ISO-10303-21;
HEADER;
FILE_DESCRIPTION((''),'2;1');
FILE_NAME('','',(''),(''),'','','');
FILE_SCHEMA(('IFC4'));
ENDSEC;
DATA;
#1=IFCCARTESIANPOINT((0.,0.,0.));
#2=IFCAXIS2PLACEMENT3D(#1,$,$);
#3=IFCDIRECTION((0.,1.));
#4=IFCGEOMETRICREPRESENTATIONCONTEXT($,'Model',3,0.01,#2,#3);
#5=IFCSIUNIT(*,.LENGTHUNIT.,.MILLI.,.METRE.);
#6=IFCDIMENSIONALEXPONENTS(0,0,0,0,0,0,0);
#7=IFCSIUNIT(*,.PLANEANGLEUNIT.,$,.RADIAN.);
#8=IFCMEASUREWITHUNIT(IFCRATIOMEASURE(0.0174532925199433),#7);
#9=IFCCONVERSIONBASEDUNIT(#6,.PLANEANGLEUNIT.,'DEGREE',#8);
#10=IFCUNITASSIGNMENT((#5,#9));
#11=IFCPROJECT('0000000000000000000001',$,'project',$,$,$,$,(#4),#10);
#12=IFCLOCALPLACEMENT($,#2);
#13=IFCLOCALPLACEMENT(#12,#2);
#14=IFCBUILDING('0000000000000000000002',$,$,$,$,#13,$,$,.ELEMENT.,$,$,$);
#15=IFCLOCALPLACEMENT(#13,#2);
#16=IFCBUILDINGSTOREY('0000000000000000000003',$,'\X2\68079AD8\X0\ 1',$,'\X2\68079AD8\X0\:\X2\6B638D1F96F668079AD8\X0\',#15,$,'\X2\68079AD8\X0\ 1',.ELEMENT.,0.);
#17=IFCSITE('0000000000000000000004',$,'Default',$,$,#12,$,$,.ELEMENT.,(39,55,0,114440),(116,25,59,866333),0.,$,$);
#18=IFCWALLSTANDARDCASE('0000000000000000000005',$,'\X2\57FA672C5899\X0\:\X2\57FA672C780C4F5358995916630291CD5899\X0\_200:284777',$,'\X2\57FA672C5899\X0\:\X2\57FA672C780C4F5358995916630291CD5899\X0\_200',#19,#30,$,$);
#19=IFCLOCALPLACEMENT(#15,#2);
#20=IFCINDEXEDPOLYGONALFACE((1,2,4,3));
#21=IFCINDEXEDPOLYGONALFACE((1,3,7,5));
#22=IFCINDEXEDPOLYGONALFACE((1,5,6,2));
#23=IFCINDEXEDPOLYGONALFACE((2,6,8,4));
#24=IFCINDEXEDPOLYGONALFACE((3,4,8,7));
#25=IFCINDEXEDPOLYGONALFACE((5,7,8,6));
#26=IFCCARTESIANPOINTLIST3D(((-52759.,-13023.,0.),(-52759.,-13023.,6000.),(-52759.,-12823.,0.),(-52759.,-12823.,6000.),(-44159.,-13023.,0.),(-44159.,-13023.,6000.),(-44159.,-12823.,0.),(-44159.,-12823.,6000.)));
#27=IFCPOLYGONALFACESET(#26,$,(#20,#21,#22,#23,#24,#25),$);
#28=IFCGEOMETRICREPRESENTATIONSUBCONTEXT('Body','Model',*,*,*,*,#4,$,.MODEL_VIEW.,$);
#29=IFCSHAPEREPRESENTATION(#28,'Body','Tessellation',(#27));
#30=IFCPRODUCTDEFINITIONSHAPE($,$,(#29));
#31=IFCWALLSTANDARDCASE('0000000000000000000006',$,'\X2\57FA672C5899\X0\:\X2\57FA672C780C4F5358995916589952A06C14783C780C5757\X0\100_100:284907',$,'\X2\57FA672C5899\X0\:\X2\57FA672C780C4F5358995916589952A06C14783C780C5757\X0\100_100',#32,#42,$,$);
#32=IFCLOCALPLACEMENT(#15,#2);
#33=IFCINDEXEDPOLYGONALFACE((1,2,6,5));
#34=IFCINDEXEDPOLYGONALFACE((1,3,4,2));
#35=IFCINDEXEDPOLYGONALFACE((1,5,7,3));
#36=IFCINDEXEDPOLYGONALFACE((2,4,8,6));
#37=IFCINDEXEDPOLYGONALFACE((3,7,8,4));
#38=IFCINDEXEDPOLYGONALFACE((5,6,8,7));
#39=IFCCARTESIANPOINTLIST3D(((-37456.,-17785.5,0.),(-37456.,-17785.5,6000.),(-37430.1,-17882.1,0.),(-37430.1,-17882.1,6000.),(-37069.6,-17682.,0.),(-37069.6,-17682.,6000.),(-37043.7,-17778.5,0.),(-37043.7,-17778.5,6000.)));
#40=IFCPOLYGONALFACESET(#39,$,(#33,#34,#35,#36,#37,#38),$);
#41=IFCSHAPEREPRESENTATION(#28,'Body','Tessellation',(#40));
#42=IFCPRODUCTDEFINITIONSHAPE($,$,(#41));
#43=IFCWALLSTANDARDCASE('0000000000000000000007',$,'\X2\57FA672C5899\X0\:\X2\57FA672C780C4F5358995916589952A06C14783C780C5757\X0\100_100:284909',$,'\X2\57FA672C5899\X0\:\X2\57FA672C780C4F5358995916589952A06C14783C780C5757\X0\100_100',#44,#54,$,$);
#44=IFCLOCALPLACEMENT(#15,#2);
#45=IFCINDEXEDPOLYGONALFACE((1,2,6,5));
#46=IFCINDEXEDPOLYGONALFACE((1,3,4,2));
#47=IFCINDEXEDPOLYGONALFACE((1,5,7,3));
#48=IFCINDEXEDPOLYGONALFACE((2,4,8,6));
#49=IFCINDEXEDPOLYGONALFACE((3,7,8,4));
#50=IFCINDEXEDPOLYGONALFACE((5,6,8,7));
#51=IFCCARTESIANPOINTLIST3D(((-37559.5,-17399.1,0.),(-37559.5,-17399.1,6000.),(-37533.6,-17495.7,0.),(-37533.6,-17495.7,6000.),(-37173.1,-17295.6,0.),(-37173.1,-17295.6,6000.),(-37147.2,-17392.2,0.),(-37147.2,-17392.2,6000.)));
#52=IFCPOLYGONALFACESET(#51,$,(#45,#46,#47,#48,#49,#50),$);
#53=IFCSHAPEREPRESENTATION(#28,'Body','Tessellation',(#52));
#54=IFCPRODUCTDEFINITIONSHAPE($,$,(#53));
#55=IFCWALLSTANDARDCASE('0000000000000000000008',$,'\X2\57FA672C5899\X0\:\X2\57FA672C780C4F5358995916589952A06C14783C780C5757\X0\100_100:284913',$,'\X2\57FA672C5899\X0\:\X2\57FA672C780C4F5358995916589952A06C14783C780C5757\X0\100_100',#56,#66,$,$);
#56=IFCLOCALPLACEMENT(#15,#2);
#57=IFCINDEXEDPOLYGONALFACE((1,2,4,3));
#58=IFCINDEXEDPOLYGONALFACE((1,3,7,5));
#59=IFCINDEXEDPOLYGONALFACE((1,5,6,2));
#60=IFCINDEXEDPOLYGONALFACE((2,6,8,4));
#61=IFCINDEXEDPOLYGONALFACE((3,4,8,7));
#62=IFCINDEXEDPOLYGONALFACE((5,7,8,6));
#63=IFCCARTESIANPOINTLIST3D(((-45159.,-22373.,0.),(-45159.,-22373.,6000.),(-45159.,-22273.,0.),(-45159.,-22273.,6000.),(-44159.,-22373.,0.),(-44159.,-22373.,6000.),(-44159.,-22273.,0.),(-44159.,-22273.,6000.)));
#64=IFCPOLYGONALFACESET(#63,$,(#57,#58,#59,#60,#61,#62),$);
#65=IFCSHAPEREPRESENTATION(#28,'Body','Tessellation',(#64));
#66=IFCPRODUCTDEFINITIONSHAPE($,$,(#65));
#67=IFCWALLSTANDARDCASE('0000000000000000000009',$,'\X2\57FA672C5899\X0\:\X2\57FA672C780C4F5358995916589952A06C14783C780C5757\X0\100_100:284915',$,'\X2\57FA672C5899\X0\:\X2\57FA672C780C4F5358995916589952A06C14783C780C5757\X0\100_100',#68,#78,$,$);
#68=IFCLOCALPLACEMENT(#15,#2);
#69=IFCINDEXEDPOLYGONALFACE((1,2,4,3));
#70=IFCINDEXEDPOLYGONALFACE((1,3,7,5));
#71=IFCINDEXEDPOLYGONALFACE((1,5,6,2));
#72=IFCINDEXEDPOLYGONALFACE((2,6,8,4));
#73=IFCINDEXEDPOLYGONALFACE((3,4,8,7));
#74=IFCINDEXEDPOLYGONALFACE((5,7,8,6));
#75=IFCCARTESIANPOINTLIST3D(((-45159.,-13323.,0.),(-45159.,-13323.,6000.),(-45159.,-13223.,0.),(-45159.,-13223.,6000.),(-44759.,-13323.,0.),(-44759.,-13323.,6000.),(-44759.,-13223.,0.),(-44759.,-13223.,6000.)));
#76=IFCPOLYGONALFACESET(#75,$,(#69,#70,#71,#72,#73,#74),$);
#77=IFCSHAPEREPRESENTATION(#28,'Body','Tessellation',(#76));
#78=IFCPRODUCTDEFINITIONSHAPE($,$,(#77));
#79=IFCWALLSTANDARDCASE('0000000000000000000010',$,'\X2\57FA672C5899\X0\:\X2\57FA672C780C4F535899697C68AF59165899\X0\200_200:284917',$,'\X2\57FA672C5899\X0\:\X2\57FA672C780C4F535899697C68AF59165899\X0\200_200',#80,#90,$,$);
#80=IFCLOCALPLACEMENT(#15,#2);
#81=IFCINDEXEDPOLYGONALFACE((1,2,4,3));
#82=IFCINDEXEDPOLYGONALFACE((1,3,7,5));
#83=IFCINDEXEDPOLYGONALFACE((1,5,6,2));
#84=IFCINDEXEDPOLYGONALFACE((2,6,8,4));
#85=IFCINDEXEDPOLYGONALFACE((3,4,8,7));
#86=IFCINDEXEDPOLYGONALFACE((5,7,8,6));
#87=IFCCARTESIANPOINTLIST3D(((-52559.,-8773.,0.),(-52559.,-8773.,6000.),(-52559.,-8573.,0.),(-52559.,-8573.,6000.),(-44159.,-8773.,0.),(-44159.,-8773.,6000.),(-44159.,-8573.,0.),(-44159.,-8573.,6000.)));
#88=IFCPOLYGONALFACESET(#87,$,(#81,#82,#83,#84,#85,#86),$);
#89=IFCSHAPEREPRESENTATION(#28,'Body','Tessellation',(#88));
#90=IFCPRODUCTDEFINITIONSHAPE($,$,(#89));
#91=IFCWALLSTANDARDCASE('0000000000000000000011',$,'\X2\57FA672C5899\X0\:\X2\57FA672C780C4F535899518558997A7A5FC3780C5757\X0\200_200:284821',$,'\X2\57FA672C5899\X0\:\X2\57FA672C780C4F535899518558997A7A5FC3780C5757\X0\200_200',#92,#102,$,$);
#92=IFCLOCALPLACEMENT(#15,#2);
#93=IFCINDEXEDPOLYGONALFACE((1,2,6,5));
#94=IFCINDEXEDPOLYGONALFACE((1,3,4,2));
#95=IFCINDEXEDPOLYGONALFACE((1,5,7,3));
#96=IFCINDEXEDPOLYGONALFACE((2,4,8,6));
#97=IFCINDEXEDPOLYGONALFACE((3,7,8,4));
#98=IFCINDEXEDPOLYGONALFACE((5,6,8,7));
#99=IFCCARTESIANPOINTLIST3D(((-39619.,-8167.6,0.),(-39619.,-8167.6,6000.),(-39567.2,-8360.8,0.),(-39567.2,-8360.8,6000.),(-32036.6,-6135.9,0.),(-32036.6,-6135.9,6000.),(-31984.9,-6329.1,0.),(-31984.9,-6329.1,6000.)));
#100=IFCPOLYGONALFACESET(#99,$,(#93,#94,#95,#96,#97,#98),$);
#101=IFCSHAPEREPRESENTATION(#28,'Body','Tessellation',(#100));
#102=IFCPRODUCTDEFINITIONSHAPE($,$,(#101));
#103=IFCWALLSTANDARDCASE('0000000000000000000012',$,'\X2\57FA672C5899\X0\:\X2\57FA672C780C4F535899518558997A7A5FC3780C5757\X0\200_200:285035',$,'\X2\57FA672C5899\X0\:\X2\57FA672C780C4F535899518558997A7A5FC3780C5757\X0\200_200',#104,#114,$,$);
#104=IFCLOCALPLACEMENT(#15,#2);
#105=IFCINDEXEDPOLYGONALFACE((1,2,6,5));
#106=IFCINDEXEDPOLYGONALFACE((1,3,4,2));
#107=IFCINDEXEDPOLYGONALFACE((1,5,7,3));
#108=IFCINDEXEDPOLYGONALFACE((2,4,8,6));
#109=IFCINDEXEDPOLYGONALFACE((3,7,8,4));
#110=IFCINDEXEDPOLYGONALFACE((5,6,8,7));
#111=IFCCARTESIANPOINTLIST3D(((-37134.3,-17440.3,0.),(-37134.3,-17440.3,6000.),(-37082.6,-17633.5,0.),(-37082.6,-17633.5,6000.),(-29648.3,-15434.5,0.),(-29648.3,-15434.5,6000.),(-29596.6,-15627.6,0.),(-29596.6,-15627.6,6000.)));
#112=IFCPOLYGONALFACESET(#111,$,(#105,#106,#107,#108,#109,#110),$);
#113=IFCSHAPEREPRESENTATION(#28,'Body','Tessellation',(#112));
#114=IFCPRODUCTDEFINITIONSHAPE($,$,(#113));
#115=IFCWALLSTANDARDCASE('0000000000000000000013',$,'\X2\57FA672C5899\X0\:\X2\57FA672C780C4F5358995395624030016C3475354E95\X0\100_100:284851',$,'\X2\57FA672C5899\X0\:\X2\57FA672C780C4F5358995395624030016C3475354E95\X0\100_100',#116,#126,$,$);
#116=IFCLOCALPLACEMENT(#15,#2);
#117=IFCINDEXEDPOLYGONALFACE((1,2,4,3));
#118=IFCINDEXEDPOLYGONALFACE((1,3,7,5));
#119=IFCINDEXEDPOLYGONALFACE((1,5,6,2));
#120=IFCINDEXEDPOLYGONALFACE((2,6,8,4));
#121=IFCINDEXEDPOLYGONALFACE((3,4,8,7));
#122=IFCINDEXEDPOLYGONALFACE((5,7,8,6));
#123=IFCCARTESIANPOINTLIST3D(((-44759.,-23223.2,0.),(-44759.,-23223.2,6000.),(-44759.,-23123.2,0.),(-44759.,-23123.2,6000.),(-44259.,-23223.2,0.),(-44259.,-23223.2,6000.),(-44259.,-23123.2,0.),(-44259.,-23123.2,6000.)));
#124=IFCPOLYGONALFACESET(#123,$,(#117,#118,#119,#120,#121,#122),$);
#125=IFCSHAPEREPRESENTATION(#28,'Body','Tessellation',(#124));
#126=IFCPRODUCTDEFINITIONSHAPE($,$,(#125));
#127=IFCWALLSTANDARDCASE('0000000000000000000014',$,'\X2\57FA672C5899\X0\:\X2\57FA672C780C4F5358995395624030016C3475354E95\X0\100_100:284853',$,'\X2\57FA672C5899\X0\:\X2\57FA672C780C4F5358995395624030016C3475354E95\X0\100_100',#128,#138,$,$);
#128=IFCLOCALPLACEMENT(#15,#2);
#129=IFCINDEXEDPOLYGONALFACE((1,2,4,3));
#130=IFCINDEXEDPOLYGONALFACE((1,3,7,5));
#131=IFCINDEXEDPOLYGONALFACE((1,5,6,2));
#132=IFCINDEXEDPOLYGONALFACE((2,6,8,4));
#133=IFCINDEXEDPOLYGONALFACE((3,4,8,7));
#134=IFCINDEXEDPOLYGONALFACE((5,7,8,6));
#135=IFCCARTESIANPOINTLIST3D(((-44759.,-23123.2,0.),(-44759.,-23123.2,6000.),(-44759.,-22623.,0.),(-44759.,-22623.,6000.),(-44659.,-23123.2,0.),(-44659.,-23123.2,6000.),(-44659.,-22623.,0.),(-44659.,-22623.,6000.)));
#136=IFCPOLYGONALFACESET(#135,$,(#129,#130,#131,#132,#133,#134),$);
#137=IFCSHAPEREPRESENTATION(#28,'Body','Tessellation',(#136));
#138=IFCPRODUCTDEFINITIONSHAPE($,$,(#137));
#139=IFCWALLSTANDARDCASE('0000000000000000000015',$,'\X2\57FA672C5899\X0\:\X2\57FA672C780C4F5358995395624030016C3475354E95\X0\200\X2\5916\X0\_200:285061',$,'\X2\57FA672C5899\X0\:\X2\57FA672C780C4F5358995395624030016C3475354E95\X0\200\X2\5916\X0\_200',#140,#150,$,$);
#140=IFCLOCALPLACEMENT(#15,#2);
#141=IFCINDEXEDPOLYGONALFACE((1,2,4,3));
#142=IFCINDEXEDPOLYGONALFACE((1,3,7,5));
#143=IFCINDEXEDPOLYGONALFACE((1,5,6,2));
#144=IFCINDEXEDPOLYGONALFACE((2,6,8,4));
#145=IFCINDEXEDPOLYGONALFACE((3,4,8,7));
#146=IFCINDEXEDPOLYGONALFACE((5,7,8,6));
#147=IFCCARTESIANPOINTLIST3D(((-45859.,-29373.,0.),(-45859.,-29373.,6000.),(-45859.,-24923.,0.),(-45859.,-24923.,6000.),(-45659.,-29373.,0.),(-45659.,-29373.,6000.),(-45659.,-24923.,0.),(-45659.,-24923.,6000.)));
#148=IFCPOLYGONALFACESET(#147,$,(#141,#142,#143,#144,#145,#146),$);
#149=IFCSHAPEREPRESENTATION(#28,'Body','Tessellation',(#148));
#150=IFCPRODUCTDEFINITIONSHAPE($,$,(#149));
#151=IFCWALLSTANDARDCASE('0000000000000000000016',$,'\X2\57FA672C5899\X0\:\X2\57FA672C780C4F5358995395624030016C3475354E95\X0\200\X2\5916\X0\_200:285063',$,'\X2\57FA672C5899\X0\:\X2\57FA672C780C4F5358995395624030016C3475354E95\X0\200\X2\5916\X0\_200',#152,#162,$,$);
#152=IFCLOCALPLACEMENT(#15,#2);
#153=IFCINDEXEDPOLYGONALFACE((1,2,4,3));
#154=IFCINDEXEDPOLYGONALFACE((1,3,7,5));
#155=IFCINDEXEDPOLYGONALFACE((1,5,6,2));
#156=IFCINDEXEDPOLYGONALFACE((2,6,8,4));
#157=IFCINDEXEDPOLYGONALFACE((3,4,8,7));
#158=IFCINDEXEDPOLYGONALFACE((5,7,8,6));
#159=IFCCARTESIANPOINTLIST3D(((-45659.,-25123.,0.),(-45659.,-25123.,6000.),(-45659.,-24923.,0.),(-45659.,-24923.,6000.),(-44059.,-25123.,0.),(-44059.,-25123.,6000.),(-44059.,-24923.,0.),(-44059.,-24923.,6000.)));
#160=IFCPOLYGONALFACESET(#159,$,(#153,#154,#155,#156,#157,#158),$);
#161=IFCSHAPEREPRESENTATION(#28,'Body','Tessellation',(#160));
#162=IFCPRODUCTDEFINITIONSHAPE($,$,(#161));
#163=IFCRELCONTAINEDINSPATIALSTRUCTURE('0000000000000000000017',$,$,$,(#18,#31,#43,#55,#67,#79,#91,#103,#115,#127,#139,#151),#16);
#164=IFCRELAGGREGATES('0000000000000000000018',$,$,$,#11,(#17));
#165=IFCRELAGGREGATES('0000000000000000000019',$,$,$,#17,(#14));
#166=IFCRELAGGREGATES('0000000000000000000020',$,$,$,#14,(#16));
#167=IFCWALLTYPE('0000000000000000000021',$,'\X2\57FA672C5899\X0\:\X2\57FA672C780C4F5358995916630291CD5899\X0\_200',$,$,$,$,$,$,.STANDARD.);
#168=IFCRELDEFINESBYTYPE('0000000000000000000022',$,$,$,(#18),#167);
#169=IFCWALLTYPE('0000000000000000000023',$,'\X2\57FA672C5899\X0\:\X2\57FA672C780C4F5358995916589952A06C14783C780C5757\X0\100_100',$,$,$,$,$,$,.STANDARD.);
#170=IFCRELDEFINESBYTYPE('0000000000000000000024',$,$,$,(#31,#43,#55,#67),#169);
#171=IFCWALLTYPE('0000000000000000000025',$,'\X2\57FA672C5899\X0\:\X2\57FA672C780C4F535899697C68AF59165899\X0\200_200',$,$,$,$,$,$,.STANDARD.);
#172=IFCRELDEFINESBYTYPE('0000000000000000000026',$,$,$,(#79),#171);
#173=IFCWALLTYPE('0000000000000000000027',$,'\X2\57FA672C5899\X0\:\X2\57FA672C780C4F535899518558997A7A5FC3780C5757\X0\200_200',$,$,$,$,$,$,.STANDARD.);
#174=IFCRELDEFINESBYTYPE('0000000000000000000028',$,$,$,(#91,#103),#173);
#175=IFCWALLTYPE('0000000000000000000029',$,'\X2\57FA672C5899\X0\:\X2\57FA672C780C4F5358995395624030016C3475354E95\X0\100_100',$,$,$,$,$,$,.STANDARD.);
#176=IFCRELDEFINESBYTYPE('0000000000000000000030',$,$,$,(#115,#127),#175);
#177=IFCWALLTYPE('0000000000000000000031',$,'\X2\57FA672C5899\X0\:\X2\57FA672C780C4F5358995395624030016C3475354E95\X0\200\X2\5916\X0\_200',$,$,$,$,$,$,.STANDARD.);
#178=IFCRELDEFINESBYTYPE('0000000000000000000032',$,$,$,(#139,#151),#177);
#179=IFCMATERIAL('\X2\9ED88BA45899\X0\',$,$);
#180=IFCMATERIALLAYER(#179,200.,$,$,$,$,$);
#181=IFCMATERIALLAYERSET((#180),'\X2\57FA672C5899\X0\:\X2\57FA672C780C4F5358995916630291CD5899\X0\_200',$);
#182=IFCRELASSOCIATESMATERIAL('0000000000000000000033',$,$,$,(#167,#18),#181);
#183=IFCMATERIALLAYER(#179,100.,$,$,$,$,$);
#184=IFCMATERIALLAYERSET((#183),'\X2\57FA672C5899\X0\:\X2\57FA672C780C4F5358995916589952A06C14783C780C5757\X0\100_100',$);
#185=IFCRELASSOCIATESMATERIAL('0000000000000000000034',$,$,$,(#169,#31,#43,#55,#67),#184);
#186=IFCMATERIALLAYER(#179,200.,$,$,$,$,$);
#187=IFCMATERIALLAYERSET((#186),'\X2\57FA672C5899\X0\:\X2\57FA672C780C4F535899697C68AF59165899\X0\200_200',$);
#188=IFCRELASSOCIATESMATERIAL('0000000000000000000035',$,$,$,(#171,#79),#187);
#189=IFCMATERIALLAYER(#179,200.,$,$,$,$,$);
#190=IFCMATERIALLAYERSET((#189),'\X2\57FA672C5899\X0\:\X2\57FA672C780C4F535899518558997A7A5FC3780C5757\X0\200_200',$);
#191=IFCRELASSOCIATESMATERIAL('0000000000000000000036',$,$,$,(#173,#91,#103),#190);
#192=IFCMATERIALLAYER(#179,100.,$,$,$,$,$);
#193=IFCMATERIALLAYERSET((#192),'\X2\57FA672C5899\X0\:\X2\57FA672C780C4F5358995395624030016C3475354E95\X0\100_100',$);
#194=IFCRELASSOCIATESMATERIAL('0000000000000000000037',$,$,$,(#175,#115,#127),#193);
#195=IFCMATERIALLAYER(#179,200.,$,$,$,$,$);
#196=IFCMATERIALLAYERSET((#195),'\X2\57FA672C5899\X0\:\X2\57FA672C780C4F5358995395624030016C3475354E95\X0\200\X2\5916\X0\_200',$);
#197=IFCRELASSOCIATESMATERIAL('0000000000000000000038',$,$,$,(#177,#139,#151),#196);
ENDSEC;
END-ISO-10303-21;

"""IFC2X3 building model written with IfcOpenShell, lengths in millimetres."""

from ifc_helpers import new_model, entity, si_unit, converted_unit, direction, frame, frame_2d, origin, place, context, subcontext, project, spatial, rectangle, extrude, material, layer, layer_set, layer_usage, type_object, element, save


model = new_model("IFC2X3")

# Units and contexts
model_context = context("Model", 3, precision=0.01, world=origin(), true_north=direction((0.0, 1.0)))
body_context = subcontext(model_context, "Body", "Model", "MODEL_VIEW")
ifc_project = project(units=[si_unit("LENGTHUNIT", "METRE", prefix="MILLI"), converted_unit("PLANEANGLEUNIT", "DEGREE", entity("IfcRatioMeasure", 0.0174532925199433), si_unit("PLANEANGLEUNIT", "RADIAN"), dimensions=[0, 0, 0, 0, 0, 0, 0])], contexts=[model_context])

# Site, building, storey
site_placement = place(None, origin())
site = spatial("IfcSite", under=ifc_project, at=site_placement, Name="Default", CompositionType="ELEMENT", RefLatitude=(39, 55, 0, 114440), RefLongitude=(116, 25, 59, 866333), RefElevation=0.0)
building_placement = place(site_placement, origin())
building = spatial("IfcBuilding", under=site, at=building_placement, CompositionType="ELEMENT")
storey_placement = place(building_placement, origin())
storey = spatial("IfcBuildingStorey", under=building, at=storey_placement, Name="标高 1", ObjectType="标高:正负零标高", LongName="标高 1", CompositionType="ELEMENT", Elevation=0.0)

# Walls
ifc_material = material(Name="默认墙")
ifc_layer_1 = layer(ifc_material, 200.0)
ifc_layer_set_1 = layer_set([ifc_layer_1], Name="基本墙:基本砌体墙外挂重墙_200")
wall_type_1 = type_object("IfcWallType", Name="基本墙:基本砌体墙外挂重墙_200", PredefinedType="STANDARD", material=ifc_layer_set_1)
ifc_layer_usage_1 = layer_usage(ifc_layer_set_1, "AXIS2", "NEGATIVE", 100.0)
wall_1_placement = place(building_placement, frame((-52759.0, -12923.0, 0.0)))
element("IfcWallStandardCase", 1, at=wall_1_placement, inside=storey, type_object=wall_type_1, material=ifc_layer_usage_1, Name="基本墙:基本砌体墙外挂重墙_200:284777", ObjectType="基本墙:基本砌体墙外挂重墙_200", context=body_context, shape_type="SweptSolid", body=[
    extrude(rectangle(XDim=8600.0, YDim=200.0, at=frame_2d((4300.0, 0.0), x_axis=(-1.0, 0.0))), origin(), (0.0, 0.0, 1.0), 6000.0),
])
ifc_layer_2 = layer(ifc_material, 100.0)
ifc_layer_set_2 = layer_set([ifc_layer_2], Name="基本墙:基本砌体墙外墙加气砼砌块100_100")
ifc_layer_usage_2 = layer_usage(ifc_layer_set_2, "AXIS2", "NEGATIVE", 50.0)
wall_type_2 = type_object("IfcWallType", Name="基本墙:基本砌体墙外墙加气砼砌块100_100", PredefinedType="STANDARD", material=ifc_layer_set_2)
wall_2_placement = place(building_placement, frame((-37443.0, -17833.8, 0.0), z_axis=(0.0, 0.0, 1.0), x_axis=(0.965926, 0.258819, 0.0)))
element("IfcWallStandardCase", 2, at=wall_2_placement, inside=storey, type_object=wall_type_2, material=ifc_layer_usage_2, Name="基本墙:基本砌体墙外墙加气砼砌块100_100:284907", ObjectType="基本墙:基本砌体墙外墙加气砼砌块100_100", context=body_context, shape_type="SweptSolid", body=[
    extrude(rectangle(XDim=400.0, YDim=100.0, at=frame_2d((200.0, 0.0), x_axis=(-1.0, 0.0))), origin(), (0.0, 0.0, 1.0), 6000.0),
])
ifc_layer_usage_3 = layer_usage(ifc_layer_set_2, "AXIS2", "NEGATIVE", 50.0)
wall_3_placement = place(building_placement, frame((-37546.5, -17447.4, 0.0), z_axis=(0.0, 0.0, 1.0), x_axis=(0.965926, 0.258819, 0.0)))
element("IfcWallStandardCase", 3, at=wall_3_placement, inside=storey, type_object=wall_type_2, material=ifc_layer_usage_3, Name="基本墙:基本砌体墙外墙加气砼砌块100_100:284909", ObjectType="基本墙:基本砌体墙外墙加气砼砌块100_100", context=body_context, shape_type="SweptSolid", body=[
    extrude(rectangle(XDim=400.0, YDim=100.0, at=frame_2d((200.0, 0.0), x_axis=(-1.0, 0.0))), origin(), (0.0, 0.0, 1.0), 6000.0),
])
ifc_layer_usage_4 = layer_usage(ifc_layer_set_2, "AXIS2", "NEGATIVE", 50.0)
wall_4_placement = place(building_placement, frame((-45159.0, -22323.0, 0.0)))
element("IfcWallStandardCase", 4, at=wall_4_placement, inside=storey, type_object=wall_type_2, material=ifc_layer_usage_4, Name="基本墙:基本砌体墙外墙加气砼砌块100_100:284913", ObjectType="基本墙:基本砌体墙外墙加气砼砌块100_100", context=body_context, shape_type="SweptSolid", body=[
    extrude(rectangle(XDim=1000.0, YDim=100.0, at=frame_2d((500.0, 0.0), x_axis=(-1.0, 0.0))), origin(), (0.0, 0.0, 1.0), 6000.0),
])
ifc_layer_usage_5 = layer_usage(ifc_layer_set_2, "AXIS2", "NEGATIVE", 50.0)
wall_5_placement = place(building_placement, frame((-45159.0, -13273.0, 0.0)))
element("IfcWallStandardCase", 5, at=wall_5_placement, inside=storey, type_object=wall_type_2, material=ifc_layer_usage_5, Name="基本墙:基本砌体墙外墙加气砼砌块100_100:284915", ObjectType="基本墙:基本砌体墙外墙加气砼砌块100_100", context=body_context, shape_type="SweptSolid", body=[
    extrude(rectangle(XDim=400.0, YDim=100.0, at=frame_2d((200.0, 0.0), x_axis=(-1.0, 0.0))), origin(), (0.0, 0.0, 1.0), 6000.0),
])
ifc_layer_3 = layer(ifc_material, 200.0)
ifc_layer_set_3 = layer_set([ifc_layer_3], Name="基本墙:基本砌体墙楼梯外墙200_200")
ifc_layer_usage_6 = layer_usage(ifc_layer_set_3, "AXIS2", "NEGATIVE", 100.0)
wall_type_3 = type_object("IfcWallType", Name="基本墙:基本砌体墙楼梯外墙200_200", PredefinedType="STANDARD", material=ifc_layer_set_3)
wall_6_placement = place(building_placement, frame((-52559.0, -8673.0, 0.0)))
element("IfcWallStandardCase", 6, at=wall_6_placement, inside=storey, type_object=wall_type_3, material=ifc_layer_usage_6, Name="基本墙:基本砌体墙楼梯外墙200_200:284917", ObjectType="基本墙:基本砌体墙楼梯外墙200_200", context=body_context, shape_type="SweptSolid", body=[
    extrude(rectangle(XDim=8400.0, YDim=200.0, at=frame_2d((4200.0, 0.0), x_axis=(-1.0, 0.0))), origin(), (0.0, 0.0, 1.0), 6000.0),
])
ifc_layer_4 = layer(ifc_material, 200.0)
ifc_layer_set_4 = layer_set([ifc_layer_4], Name="基本墙:基本砌体墙内墙空心砌块200_200")
ifc_layer_usage_7 = layer_usage(ifc_layer_set_4, "AXIS2", "NEGATIVE", 100.0)
wall_type_4 = type_object("IfcWallType", Name="基本墙:基本砌体墙内墙空心砌块200_200", PredefinedType="STANDARD", material=ifc_layer_set_4)
wall_7_placement = place(building_placement, frame((-39593.1, -8264.2, 0.0), z_axis=(0.0, 0.0, 1.0), x_axis=(0.965926, 0.258819, 0.0)))
element("IfcWallStandardCase", 7, at=wall_7_placement, inside=storey, type_object=wall_type_4, material=ifc_layer_usage_7, Name="基本墙:基本砌体墙内墙空心砌块200_200:284821", ObjectType="基本墙:基本砌体墙内墙空心砌块200_200", context=body_context, shape_type="SweptSolid", body=[
    extrude(rectangle(XDim=7849.8, YDim=200.0, at=frame_2d((3924.9, 0.0), x_axis=(-1.0, 0.0))), origin(), (0.0, 0.0, 1.0), 6000.0),
])
ifc_layer_usage_8 = layer_usage(ifc_layer_set_4, "AXIS2", "NEGATIVE", 100.0)
wall_8_placement = place(building_placement, frame((-37108.4, -17536.9, 0.0), z_axis=(0.0, 0.0, 1.0), x_axis=(0.965926, 0.258819, 0.0)))
element("IfcWallStandardCase", 8, at=wall_8_placement, inside=storey, type_object=wall_type_4, material=ifc_layer_usage_8, Name="基本墙:基本砌体墙内墙空心砌块200_200:285035", ObjectType="基本墙:基本砌体墙内墙空心砌块200_200", context=body_context, shape_type="SweptSolid", body=[
    extrude(rectangle(XDim=7750.1, YDim=200.0, at=frame_2d((3875.0, 0.0), x_axis=(-1.0, 0.0))), origin(), (0.0, 0.0, 1.0), 6000.0),
])
ifc_layer_5 = layer(ifc_material, 100.0)
ifc_layer_set_5 = layer_set([ifc_layer_5], Name="基本墙:基本砌体墙厕所、水电井100_100")
ifc_layer_usage_9 = layer_usage(ifc_layer_set_5, "AXIS2", "NEGATIVE", 50.0)
wall_type_5 = type_object("IfcWallType", Name="基本墙:基本砌体墙厕所、水电井100_100", PredefinedType="STANDARD", material=ifc_layer_set_5)
wall_9_placement = place(building_placement, frame((-44759.0, -23173.2, 0.0)))
element("IfcWallStandardCase", 9, at=wall_9_placement, inside=storey, type_object=wall_type_5, material=ifc_layer_usage_9, Name="基本墙:基本砌体墙厕所、水电井100_100:284851", ObjectType="基本墙:基本砌体墙厕所、水电井100_100", context=body_context, shape_type="SweptSolid", body=[
    extrude(rectangle(XDim=500.0, YDim=100.0, at=frame_2d((250.0, 0.0), x_axis=(-1.0, 0.0))), origin(), (0.0, 0.0, 1.0), 6000.0),
])
ifc_layer_usage_10 = layer_usage(ifc_layer_set_5, "AXIS2", "NEGATIVE", 50.0)
wall_10_placement = place(building_placement, frame((-44709.0, -22623.0, 0.0), z_axis=(0.0, 0.0, 1.0), x_axis=(0.0, -1.0, 0.0)))
element("IfcWallStandardCase", 10, at=wall_10_placement, inside=storey, type_object=wall_type_5, material=ifc_layer_usage_10, Name="基本墙:基本砌体墙厕所、水电井100_100:284853", ObjectType="基本墙:基本砌体墙厕所、水电井100_100", context=body_context, shape_type="SweptSolid", body=[
    extrude(rectangle(XDim=500.2, YDim=100.0, at=frame_2d((250.1, 0.0), x_axis=(-1.0, 0.0))), origin(), (0.0, 0.0, 1.0), 6000.0),
])
ifc_layer_6 = layer(ifc_material, 200.0)
ifc_layer_set_6 = layer_set([ifc_layer_6], Name="基本墙:基本砌体墙厕所、水电井200外_200")
ifc_layer_usage_11 = layer_usage(ifc_layer_set_6, "AXIS2", "NEGATIVE", 100.0)
wall_type_6 = type_object("IfcWallType", Name="基本墙:基本砌体墙厕所、水电井200外_200", PredefinedType="STANDARD", material=ifc_layer_set_6)
wall_11_placement = place(building_placement, frame((-45759.0, -24923.0, 0.0), z_axis=(0.0, 0.0, 1.0), x_axis=(0.0, -1.0, 0.0)))
element("IfcWallStandardCase", 11, at=wall_11_placement, inside=storey, type_object=wall_type_6, material=ifc_layer_usage_11, Name="基本墙:基本砌体墙厕所、水电井200外_200:285061", ObjectType="基本墙:基本砌体墙厕所、水电井200外_200", context=body_context, shape_type="SweptSolid", body=[
    extrude(rectangle(XDim=4450.0, YDim=200.0, at=frame_2d((2225.0, 0.0), x_axis=(-1.0, 0.0))), origin(), (0.0, 0.0, 1.0), 6000.0),
])
ifc_layer_usage_12 = layer_usage(ifc_layer_set_6, "AXIS2", "NEGATIVE", 100.0)
wall_12_placement = place(building_placement, frame((-44059.0, -25023.0, 0.0), z_axis=(0.0, 0.0, 1.0), x_axis=(-1.0, 0.0, 0.0)))
element("IfcWallStandardCase", 12, at=wall_12_placement, inside=storey, type_object=wall_type_6, material=ifc_layer_usage_12, Name="基本墙:基本砌体墙厕所、水电井200外_200:285063", ObjectType="基本墙:基本砌体墙厕所、水电井200外_200", context=body_context, shape_type="SweptSolid", body=[
    extrude(rectangle(XDim=1600.0, YDim=200.0, at=frame_2d((800.0, 0.0), x_axis=(-1.0, 0.0))), origin(), (0.0, 0.0, 1.0), 6000.0),
])

save(model, "model.ifc")
